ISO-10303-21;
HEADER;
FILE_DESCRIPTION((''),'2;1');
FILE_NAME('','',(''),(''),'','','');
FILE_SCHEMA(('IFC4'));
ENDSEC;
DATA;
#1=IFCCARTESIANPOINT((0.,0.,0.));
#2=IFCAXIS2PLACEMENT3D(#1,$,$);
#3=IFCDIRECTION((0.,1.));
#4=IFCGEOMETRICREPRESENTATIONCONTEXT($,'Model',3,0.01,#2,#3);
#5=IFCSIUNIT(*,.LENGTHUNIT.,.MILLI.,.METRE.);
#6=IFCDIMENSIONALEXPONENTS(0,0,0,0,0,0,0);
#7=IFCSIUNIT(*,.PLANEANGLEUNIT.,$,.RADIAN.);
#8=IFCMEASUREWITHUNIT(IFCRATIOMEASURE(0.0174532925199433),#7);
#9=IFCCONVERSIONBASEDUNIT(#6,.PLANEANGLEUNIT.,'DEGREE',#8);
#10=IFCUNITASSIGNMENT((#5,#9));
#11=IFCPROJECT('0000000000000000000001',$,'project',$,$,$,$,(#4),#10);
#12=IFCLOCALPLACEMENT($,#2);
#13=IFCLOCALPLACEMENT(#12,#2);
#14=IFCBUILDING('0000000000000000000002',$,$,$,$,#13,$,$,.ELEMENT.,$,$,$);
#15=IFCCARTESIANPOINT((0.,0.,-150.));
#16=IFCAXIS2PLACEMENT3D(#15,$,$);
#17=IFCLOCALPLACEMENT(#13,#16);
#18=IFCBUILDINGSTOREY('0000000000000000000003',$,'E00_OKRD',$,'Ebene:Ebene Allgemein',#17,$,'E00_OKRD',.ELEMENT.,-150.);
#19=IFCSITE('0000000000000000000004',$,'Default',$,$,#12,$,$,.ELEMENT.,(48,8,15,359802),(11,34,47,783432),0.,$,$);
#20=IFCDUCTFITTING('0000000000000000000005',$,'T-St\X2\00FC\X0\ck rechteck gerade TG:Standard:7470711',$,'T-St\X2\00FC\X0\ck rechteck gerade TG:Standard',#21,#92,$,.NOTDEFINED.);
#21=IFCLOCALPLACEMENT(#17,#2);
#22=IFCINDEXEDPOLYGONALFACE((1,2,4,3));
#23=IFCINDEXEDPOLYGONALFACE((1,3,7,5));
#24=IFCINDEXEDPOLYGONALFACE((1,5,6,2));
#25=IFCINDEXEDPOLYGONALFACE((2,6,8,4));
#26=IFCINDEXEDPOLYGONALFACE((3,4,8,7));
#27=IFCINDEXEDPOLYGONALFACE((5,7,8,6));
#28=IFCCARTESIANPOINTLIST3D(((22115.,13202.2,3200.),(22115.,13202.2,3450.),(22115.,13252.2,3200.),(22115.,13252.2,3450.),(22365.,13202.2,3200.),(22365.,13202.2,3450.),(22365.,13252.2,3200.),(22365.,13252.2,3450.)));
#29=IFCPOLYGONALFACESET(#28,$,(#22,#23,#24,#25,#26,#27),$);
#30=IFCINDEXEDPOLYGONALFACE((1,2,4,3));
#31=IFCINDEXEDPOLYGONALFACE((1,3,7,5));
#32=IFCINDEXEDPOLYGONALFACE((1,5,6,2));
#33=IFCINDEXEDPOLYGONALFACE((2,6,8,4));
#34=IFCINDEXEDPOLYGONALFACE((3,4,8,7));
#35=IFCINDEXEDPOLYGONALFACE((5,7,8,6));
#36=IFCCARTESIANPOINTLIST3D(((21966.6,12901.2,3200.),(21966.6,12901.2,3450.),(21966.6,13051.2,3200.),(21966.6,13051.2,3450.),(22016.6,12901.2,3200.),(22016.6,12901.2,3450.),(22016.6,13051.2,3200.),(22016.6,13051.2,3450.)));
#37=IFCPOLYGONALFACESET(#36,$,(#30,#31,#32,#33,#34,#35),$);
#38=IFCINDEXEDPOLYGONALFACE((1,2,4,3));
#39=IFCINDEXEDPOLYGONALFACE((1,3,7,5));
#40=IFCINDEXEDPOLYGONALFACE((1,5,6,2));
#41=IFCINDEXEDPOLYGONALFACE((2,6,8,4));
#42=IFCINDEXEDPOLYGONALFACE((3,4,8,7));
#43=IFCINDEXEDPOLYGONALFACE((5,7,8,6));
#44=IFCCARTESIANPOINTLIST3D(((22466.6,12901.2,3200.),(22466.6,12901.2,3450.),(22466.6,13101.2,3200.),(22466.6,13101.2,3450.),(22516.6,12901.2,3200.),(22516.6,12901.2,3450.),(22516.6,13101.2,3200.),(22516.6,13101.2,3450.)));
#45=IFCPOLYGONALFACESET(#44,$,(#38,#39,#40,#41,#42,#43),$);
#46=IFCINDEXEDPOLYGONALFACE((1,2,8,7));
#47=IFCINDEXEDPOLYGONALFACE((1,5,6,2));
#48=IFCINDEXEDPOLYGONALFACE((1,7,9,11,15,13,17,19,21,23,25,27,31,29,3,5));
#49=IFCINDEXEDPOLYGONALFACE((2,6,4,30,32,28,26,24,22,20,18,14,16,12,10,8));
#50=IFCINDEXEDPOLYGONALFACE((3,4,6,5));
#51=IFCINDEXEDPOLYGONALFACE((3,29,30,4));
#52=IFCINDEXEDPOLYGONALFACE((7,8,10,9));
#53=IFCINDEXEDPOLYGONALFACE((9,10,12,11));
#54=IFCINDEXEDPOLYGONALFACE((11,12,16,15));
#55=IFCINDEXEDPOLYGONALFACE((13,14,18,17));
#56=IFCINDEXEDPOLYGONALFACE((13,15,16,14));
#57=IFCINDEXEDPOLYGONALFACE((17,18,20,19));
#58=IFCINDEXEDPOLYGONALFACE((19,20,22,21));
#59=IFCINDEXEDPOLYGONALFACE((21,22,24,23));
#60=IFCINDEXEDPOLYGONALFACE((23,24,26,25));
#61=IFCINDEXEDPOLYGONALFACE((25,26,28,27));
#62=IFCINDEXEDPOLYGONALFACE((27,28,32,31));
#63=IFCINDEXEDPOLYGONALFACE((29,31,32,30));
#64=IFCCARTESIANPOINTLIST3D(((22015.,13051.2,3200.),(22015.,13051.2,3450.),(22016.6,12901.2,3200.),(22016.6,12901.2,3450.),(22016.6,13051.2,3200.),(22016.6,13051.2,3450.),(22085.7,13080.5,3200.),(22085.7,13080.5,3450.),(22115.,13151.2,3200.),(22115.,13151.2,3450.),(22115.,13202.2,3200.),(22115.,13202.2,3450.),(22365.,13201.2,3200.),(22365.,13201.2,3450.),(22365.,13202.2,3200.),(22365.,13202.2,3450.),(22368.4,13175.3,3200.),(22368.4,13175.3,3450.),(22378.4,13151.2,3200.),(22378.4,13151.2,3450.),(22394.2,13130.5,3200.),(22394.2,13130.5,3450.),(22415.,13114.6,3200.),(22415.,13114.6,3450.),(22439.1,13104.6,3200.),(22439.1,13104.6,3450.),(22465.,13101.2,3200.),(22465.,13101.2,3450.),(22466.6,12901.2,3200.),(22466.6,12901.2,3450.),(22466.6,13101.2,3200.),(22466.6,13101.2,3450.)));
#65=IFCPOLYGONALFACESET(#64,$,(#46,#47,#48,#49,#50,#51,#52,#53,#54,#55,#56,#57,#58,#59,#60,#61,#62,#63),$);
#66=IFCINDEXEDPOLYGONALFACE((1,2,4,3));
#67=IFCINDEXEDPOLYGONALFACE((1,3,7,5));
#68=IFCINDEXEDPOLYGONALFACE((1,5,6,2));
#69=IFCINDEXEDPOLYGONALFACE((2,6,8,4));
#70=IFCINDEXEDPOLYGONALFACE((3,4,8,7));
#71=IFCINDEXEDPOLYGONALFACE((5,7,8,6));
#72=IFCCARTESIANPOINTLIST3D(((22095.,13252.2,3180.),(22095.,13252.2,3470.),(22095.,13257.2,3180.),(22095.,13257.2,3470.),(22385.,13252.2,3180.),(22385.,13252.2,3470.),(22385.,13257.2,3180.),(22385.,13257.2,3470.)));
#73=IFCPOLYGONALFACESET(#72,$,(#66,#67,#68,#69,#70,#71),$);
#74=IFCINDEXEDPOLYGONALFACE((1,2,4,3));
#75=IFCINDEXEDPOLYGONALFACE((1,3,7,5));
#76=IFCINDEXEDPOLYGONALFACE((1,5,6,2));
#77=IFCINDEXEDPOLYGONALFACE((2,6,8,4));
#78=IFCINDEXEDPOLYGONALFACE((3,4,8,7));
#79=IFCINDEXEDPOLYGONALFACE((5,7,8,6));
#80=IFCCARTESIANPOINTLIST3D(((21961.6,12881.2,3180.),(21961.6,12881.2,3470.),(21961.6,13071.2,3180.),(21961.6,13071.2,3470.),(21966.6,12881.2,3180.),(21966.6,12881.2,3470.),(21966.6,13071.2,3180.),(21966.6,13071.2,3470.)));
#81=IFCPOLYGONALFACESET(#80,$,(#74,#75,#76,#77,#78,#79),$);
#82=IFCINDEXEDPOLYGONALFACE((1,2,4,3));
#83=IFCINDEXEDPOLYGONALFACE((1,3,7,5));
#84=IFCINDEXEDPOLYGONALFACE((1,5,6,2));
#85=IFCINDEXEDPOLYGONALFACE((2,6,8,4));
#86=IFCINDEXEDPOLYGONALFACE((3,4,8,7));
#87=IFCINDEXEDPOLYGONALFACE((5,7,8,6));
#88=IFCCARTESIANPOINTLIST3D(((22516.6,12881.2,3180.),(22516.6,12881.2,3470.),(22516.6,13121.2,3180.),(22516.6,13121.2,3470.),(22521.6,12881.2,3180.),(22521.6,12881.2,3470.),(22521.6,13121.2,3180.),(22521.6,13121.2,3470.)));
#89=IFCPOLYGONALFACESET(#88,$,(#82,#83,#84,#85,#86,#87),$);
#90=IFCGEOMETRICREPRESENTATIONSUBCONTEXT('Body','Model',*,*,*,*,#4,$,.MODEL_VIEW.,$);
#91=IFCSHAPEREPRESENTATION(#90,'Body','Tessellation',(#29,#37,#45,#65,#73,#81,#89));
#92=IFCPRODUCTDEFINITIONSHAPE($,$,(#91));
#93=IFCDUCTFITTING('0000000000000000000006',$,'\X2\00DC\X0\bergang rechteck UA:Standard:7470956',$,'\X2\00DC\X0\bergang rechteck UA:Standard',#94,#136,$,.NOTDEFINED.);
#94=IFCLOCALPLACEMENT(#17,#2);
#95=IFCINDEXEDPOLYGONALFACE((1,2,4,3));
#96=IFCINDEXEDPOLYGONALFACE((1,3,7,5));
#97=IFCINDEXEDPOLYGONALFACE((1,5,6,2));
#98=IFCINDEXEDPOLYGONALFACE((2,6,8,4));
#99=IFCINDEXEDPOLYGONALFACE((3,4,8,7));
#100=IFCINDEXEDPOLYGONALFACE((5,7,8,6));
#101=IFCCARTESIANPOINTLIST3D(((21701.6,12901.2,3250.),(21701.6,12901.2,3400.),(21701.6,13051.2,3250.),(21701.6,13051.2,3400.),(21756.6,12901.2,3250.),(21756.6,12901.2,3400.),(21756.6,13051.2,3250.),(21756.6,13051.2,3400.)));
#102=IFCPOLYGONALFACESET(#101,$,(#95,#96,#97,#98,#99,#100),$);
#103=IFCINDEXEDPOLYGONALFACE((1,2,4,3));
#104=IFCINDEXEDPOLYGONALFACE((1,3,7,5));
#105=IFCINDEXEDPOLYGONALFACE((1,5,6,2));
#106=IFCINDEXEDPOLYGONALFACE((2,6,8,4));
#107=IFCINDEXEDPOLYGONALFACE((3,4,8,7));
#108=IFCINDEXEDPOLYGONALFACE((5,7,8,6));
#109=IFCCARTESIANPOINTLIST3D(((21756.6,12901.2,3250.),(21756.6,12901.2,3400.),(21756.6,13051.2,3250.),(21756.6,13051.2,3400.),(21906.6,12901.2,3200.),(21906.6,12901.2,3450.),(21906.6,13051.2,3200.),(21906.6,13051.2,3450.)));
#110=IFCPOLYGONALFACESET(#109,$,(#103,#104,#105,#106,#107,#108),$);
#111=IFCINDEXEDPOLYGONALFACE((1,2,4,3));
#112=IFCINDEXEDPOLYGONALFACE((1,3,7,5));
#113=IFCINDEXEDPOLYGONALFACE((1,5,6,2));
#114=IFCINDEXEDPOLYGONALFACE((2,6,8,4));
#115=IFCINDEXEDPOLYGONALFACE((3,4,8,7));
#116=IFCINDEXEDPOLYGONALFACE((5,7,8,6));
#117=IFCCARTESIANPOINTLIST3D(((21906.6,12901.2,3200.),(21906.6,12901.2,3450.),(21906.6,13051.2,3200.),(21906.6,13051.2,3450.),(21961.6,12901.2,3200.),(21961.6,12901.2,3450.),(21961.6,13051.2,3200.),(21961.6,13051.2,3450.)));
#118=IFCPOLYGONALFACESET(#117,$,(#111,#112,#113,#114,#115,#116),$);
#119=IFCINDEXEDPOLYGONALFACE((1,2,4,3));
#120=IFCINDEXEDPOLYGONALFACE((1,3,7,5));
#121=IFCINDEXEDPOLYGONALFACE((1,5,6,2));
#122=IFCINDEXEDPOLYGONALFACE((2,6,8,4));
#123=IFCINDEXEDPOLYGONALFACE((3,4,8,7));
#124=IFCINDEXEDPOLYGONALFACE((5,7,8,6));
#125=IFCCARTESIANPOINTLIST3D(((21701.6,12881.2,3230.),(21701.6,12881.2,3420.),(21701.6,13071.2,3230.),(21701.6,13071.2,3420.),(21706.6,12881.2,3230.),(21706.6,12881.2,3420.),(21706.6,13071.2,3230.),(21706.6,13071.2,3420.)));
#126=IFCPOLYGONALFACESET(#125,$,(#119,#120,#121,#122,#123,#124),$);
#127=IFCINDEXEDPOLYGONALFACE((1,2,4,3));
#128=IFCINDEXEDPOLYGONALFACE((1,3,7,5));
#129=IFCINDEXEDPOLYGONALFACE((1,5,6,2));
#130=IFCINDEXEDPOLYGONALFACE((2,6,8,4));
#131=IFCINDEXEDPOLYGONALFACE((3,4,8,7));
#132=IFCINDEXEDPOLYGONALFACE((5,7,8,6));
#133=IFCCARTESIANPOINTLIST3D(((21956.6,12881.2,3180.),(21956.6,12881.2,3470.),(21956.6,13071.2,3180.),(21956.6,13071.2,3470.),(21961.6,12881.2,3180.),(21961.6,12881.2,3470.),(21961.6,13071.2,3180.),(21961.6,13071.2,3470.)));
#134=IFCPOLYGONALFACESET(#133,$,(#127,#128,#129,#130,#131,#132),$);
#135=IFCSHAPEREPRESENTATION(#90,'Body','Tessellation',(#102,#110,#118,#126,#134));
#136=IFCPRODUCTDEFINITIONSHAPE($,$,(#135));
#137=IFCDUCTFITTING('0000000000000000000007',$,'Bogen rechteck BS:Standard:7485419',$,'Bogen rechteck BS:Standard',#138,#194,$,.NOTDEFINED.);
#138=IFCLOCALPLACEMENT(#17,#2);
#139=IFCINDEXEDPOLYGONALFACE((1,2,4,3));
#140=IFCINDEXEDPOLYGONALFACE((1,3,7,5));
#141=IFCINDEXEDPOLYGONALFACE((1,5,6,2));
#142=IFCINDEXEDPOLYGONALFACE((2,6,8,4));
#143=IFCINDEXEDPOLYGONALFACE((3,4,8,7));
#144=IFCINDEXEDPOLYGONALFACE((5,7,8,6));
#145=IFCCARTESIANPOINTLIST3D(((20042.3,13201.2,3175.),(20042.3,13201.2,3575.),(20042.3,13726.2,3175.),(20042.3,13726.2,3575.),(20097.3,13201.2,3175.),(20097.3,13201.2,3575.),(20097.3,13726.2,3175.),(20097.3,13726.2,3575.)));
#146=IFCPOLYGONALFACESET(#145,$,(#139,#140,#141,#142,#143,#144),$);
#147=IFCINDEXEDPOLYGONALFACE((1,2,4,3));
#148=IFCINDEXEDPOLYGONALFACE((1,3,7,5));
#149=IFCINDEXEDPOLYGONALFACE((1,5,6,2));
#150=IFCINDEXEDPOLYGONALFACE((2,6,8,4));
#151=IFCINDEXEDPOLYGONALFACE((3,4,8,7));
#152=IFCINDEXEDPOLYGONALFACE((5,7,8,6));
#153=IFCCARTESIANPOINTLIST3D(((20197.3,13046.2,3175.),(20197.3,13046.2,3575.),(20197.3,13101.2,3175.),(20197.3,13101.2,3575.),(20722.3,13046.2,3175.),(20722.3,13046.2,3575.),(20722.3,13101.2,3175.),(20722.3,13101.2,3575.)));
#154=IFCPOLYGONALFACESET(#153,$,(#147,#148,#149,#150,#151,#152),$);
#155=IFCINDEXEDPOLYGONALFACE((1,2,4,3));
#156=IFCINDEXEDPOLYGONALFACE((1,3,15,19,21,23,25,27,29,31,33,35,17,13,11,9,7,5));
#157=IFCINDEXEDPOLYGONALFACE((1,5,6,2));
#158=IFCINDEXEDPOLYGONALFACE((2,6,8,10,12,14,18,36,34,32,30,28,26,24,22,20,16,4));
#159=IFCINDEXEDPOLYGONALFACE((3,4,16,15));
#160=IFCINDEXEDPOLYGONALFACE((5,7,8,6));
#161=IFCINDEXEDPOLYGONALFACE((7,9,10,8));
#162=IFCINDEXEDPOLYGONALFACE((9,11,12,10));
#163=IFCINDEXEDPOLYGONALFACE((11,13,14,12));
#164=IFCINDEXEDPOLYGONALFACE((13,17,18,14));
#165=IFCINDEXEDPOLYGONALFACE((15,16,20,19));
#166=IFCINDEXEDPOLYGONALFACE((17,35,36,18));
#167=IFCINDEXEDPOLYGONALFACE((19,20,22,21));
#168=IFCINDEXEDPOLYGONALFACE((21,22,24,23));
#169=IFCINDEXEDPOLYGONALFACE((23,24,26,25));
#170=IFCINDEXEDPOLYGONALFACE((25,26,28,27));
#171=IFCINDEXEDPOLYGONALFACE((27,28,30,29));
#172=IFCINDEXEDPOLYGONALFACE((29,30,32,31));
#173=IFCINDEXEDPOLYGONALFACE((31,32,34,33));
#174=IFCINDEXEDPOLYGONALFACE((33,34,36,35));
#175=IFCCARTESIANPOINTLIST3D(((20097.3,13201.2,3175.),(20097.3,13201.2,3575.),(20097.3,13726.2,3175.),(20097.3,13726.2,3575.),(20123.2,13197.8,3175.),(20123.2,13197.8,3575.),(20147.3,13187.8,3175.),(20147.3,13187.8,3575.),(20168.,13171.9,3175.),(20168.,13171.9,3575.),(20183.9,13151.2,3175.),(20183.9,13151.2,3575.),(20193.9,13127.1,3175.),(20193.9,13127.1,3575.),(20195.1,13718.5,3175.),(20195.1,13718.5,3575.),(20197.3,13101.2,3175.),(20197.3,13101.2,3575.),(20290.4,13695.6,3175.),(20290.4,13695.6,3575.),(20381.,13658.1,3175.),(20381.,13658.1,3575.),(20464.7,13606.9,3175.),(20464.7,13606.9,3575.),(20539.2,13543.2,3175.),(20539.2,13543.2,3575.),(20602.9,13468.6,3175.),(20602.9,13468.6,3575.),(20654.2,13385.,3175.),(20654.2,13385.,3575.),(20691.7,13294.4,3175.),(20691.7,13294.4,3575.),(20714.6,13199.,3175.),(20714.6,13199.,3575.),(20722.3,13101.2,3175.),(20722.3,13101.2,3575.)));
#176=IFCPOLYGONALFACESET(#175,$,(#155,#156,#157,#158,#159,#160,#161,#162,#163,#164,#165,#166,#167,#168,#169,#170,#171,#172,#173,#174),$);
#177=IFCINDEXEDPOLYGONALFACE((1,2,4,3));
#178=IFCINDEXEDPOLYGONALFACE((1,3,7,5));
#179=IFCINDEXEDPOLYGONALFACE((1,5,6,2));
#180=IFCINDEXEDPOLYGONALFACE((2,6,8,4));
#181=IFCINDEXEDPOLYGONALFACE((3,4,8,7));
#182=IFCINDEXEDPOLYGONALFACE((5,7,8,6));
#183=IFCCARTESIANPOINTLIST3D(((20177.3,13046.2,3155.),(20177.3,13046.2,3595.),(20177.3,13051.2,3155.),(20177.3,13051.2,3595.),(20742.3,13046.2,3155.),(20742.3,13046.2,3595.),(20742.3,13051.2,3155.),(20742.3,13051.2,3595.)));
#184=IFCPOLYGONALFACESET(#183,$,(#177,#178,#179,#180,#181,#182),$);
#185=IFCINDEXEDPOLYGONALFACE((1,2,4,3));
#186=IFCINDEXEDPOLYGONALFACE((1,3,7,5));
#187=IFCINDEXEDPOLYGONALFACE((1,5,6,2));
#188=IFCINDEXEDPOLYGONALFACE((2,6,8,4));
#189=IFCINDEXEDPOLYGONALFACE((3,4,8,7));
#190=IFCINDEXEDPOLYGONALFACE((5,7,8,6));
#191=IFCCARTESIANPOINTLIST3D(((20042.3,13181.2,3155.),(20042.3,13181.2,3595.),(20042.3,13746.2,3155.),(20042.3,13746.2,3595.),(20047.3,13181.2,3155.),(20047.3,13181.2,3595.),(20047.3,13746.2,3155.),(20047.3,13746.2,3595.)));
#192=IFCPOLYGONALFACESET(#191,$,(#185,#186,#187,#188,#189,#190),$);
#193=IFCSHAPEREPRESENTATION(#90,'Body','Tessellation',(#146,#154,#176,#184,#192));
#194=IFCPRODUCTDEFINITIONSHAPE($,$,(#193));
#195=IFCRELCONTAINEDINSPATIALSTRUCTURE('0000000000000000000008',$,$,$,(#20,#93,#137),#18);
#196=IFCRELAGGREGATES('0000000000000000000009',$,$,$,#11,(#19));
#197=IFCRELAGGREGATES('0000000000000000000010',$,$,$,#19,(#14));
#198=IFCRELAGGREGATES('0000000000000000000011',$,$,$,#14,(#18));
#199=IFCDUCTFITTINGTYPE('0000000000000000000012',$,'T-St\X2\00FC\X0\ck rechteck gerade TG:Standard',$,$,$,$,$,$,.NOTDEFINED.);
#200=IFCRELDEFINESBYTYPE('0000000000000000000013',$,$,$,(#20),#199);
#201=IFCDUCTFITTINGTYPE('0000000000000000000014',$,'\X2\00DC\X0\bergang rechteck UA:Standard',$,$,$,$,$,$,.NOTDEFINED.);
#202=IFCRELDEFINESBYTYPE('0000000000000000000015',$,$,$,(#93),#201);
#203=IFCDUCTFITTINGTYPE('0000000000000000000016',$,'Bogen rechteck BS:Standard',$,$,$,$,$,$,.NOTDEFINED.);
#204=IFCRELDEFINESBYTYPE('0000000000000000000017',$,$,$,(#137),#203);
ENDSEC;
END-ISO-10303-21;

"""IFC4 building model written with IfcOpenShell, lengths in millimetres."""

from ifc_helpers import new_model, entity, si_unit, converted_unit, direction, frame, frame_2d, origin, origin_2d_with_axis, place, context, subcontext, project, spatial, polyline, circle_curve, parameter, trimmed, segment, composite_curve, rectangle, outline, extrude, source, transform, mapped, type_object, type_shapes, element, save


model = new_model("IFC4")

# Units and contexts
model_context = context("Model", 3, precision=0.01, world=origin(), true_north=direction((0.0, 1.0)))
body_context = subcontext(model_context, "Body", "Model", "MODEL_VIEW")
ifc_project = project(units=[si_unit("LENGTHUNIT", "METRE", prefix="MILLI"), converted_unit("PLANEANGLEUNIT", "DEGREE", entity("IfcRatioMeasure", 0.0174532925199433), si_unit("PLANEANGLEUNIT", "RADIAN"), dimensions=[0, 0, 0, 0, 0, 0, 0])], contexts=[model_context])

# Site, building, storey
site_placement = place(None, origin())
site = spatial("IfcSite", under=ifc_project, at=site_placement, Name="Default", CompositionType="ELEMENT", RefLatitude=(48, 8, 15, 359802), RefLongitude=(11, 34, 47, 783432), RefElevation=0.0)
building_placement = place(site_placement, origin())
building = spatial("IfcBuilding", under=site, at=building_placement, CompositionType="ELEMENT")
storey_placement = place(building_placement, frame((0.0, 0.0, -150.0)))
storey = spatial("IfcBuildingStorey", under=building, at=storey_placement, Name="E00_OKRD", ObjectType="Ebene:Ebene Allgemein", LongName="E00_OKRD", CompositionType="ELEMENT", Elevation=-150.0)

# Duct fittings
duct_fitting_type_1 = type_object("IfcDuctFittingType", Name="T-Stück rechteck gerade TG:Standard", PredefinedType="NOTDEFINED")
shared_shape_1 = source(origin(), body_context, "Body", "SweptSolid", [
    extrude(rectangle(XDim=50.0, YDim=250.0, at=frame_2d((0.0, 0.0), x_axis=(1.0, 0.0))), frame((0.0, -238.5, -125.0), z_axis=(0.0, 0.0, 1.0), x_axis=(0.0, -1.0, 0.0)), (0.0, 0.0, 1.0), 250.0),
    extrude(rectangle(XDim=50.0, YDim=150.0, at=frame_2d((0.0, 0.0), x_axis=(1.0, 0.0))), frame((248.4, 12.5, -125.0), z_axis=(0.0, 0.0, 1.0), x_axis=(-1.0, 0.0, 0.0)), (0.0, 0.0, 1.0), 250.0),
    extrude(rectangle(XDim=50.0, YDim=200.0, at=origin_2d_with_axis()), frame((-251.6, -12.5, -125.0)), (0.0, 0.0, 1.0), 250.0),
    extrude(outline(composite_curve([segment(trimmed(circle_curve(frame_2d((-225.6, -64.8), x_axis=(-1.0, 0.0)), 100.0), [parameter(180.0)], [parameter(270.0)], True, "PARAMETER"), False, "CONTINUOUS"), segment(polyline([(-125.6, -64.8), (-125.6, -115.8)]), True, "CONTINUOUS"), segment(polyline([(-125.6, -115.8), (124.4, -115.8)]), True, "CONTINUOUS"), segment(polyline([(124.4, -115.8), (124.4, -114.8)]), True, "CONTINUOUS"), segment(trimmed(circle_curve(frame_2d((224.4, -114.8), x_axis=(-1.0, 0.0)), 100.0), [parameter(270.0)], [parameter(0.0)], True, "PARAMETER"), False, "CONTINUOUS"), segment(polyline([(224.4, -14.8), (226.0, -14.8)]), True, "CONTINUOUS"), segment(polyline([(226.0, -14.8), (226.0, 185.2)]), True, "CONTINUOUS"), segment(polyline([(226.0, 185.2), (-224.0, 185.2)]), True, "CONTINUOUS"), segment(polyline([(-224.0, 185.2), (-224.0, 35.2)]), True, "CONTINUOUS"), segment(polyline([(-224.0, 35.2), (-225.6, 35.2)]), True, "CONTINUOUS")], self_intersect=False)), frame((-0.6, -97.7, -125.0), z_axis=(0.0, 0.0, -1.0), x_axis=(-1.0, 0.0, 0.0)), (0.0, 0.0, -1.0), 250.0),
    extrude(rectangle(XDim=5.0, YDim=290.0, at=frame_2d((0.0, 0.0), x_axis=(1.0, 0.0))), frame((0.0, -266.0, -145.0), z_axis=(0.0, 0.0, 1.0), x_axis=(0.0, 1.0, 0.0)), (0.0, 0.0, 1.0), 290.0),
    extrude(rectangle(XDim=5.0, YDim=190.0, at=origin_2d_with_axis()), frame((275.9, 12.5, -145.0), z_axis=(0.0, 0.0, 1.0), x_axis=(-1.0, 0.0, 0.0)), (0.0, 0.0, 1.0), 290.0),
    extrude(rectangle(XDim=5.0, YDim=240.0, at=origin_2d_with_axis()), frame((-279.1, -12.5, -145.0), z_axis=(0.0, 0.0, 1.0), x_axis=(-1.0, 0.0, 0.0)), (0.0, 0.0, 1.0), 290.0),
])
type_shapes(duct_fitting_type_1, [shared_shape_1])
duct_fitting_1_placement = place(storey_placement, frame((22240.0, 12988.7, 3325.0), z_axis=(0.0, 0.0, 1.0), x_axis=(-1.0, 0.0, 0.0)))
element("IfcDuctFitting", 1, at=duct_fitting_1_placement, inside=storey, type_object=duct_fitting_type_1, Name="T-Stück rechteck gerade TG:Standard:7470711", ObjectType="T-Stück rechteck gerade TG:Standard", PredefinedType="NOTDEFINED", context=body_context, shape_type="MappedRepresentation", body=[
    mapped(shared_shape_1, transform((0.0, 0.0, 0.0), scale=1.0)),
])
duct_fitting_type_2 = type_object("IfcDuctFittingType", Name="Übergang rechteck UA:Standard", PredefinedType="NOTDEFINED")
shared_shape_2 = source(origin(), body_context, "Body", "SweptSolid", [
    extrude(rectangle(XDim=55.0, YDim=150.0, at=origin_2d_with_axis()), frame((232.5, 0.0, -75.0)), (0.0, 0.0, 1.0), 150.0),
    extrude(outline(polyline([(-110.7, -94.9), (47.4, -94.9), (94.9, 47.4), (-31.6, 142.3), (-110.7, -94.9)])), frame((130.0, -75.0, 0.0), z_axis=(0.0, 1.0, 0.0), x_axis=(0.948683, 0.0, -0.316228)), (0.0, 0.0, 1.0), 150.0),
    extrude(rectangle(XDim=55.0, YDim=150.0, at=frame_2d((0.0, 0.0), x_axis=(1.0, 0.0))), frame((27.5, 0.0, -125.0)), (0.0, 0.0, 1.0), 250.0),
    extrude(rectangle(XDim=5.0, YDim=190.0, at=origin_2d_with_axis()), frame((257.5, 0.0, -95.0)), (0.0, 0.0, 1.0), 190.0),
    extrude(rectangle(XDim=5.0, YDim=190.0, at=frame_2d((0.0, 0.0), x_axis=(1.0, 0.0))), frame((2.5, 0.0, -145.0)), (0.0, 0.0, 1.0), 290.0),
])
type_shapes(duct_fitting_type_2, [shared_shape_2])
duct_fitting_2_placement = place(storey_placement, frame((21961.6, 12976.2, 3325.0), z_axis=(0.0, 0.0, 1.0), x_axis=(-1.0, 0.0, 0.0)))
element("IfcDuctFitting", 2, at=duct_fitting_2_placement, inside=storey, type_object=duct_fitting_type_2, Name="Übergang rechteck UA:Standard:7470956", ObjectType="Übergang rechteck UA:Standard", PredefinedType="NOTDEFINED", context=body_context, shape_type="MappedRepresentation", body=[
    mapped(shared_shape_2, transform((0.0, 0.0, 0.0), scale=1.0)),
])
duct_fitting_type_3 = type_object("IfcDuctFittingType", Name="Bogen rechteck BS:Standard", PredefinedType="NOTDEFINED")
shared_shape_3 = source(origin(), body_context, "Body", "SweptSolid", [
    extrude(rectangle(XDim=55.0, YDim=525.0, at=origin_2d_with_axis()), frame((0.0, 390.0, -200.0), z_axis=(0.0, 0.0, 1.0), x_axis=(0.0, 1.0, 0.0)), (0.0, 0.0, 1.0), 400.0),
    extrude(rectangle(XDim=525.0, YDim=55.0, at=frame_2d((0.0, 0.0), x_axis=(1.0, 0.0))), frame((-390.0, 0.0, -200.0), z_axis=(0.0, 0.0, 1.0), x_axis=(0.0, -1.0, 0.0)), (0.0, 0.0, 1.0), 400.0),
    extrude(outline(composite_curve([segment(polyline([(-443.8, -181.2), (81.2, -181.2)]), True, "CONTINUOUS"), segment(trimmed(circle_curve(frame_2d((181.2, -181.2), x_axis=(0.0, 1.0)), 100.0), [parameter(0.0)], [parameter(90.0)], True, "PARAMETER"), False, "CONTINUOUS"), segment(polyline([(181.2, -81.2), (181.2, 443.8)]), True, "CONTINUOUS"), segment(trimmed(circle_curve(frame_2d((181.2, -181.2), x_axis=(0.0, 1.0)), 625.0), [parameter(0.0)], [parameter(90.0)], True, "PARAMETER"), True, "CONTINUOUS")], self_intersect=False)), frame((-181.2, 181.3, -200.0), z_axis=(0.0, 0.0, 1.0), x_axis=(-1.0, 0.0, 0.0)), (0.0, 0.0, 1.0), 400.0),
    extrude(rectangle(XDim=5.0, YDim=565.0, at=frame_2d((0.0, 0.0), x_axis=(1.0, 0.0))), frame((-415.0, 0.0, -220.0)), (0.0, 0.0, 1.0), 440.0),
    extrude(rectangle(XDim=5.0, YDim=565.0, at=frame_2d((0.0, 0.0), x_axis=(1.0, 0.0))), frame((0.0, 415.0, -220.0), z_axis=(0.0, 0.0, 1.0), x_axis=(0.0, 1.0, 0.0)), (0.0, 0.0, 1.0), 440.0),
])
type_shapes(duct_fitting_type_3, [shared_shape_3])
duct_fitting_3_placement = place(storey_placement, frame((20459.8, 13463.7, 3375.0), z_axis=(0.0, 0.0, 1.0), x_axis=(0.0, 1.0, 0.0)))
element("IfcDuctFitting", 3, at=duct_fitting_3_placement, inside=storey, type_object=duct_fitting_type_3, Name="Bogen rechteck BS:Standard:7485419", ObjectType="Bogen rechteck BS:Standard", PredefinedType="NOTDEFINED", context=body_context, shape_type="MappedRepresentation", body=[
    mapped(shared_shape_3, transform((0.0, 0.0, 0.0), scale=1.0)),
])

save(model, "model.ifc")
